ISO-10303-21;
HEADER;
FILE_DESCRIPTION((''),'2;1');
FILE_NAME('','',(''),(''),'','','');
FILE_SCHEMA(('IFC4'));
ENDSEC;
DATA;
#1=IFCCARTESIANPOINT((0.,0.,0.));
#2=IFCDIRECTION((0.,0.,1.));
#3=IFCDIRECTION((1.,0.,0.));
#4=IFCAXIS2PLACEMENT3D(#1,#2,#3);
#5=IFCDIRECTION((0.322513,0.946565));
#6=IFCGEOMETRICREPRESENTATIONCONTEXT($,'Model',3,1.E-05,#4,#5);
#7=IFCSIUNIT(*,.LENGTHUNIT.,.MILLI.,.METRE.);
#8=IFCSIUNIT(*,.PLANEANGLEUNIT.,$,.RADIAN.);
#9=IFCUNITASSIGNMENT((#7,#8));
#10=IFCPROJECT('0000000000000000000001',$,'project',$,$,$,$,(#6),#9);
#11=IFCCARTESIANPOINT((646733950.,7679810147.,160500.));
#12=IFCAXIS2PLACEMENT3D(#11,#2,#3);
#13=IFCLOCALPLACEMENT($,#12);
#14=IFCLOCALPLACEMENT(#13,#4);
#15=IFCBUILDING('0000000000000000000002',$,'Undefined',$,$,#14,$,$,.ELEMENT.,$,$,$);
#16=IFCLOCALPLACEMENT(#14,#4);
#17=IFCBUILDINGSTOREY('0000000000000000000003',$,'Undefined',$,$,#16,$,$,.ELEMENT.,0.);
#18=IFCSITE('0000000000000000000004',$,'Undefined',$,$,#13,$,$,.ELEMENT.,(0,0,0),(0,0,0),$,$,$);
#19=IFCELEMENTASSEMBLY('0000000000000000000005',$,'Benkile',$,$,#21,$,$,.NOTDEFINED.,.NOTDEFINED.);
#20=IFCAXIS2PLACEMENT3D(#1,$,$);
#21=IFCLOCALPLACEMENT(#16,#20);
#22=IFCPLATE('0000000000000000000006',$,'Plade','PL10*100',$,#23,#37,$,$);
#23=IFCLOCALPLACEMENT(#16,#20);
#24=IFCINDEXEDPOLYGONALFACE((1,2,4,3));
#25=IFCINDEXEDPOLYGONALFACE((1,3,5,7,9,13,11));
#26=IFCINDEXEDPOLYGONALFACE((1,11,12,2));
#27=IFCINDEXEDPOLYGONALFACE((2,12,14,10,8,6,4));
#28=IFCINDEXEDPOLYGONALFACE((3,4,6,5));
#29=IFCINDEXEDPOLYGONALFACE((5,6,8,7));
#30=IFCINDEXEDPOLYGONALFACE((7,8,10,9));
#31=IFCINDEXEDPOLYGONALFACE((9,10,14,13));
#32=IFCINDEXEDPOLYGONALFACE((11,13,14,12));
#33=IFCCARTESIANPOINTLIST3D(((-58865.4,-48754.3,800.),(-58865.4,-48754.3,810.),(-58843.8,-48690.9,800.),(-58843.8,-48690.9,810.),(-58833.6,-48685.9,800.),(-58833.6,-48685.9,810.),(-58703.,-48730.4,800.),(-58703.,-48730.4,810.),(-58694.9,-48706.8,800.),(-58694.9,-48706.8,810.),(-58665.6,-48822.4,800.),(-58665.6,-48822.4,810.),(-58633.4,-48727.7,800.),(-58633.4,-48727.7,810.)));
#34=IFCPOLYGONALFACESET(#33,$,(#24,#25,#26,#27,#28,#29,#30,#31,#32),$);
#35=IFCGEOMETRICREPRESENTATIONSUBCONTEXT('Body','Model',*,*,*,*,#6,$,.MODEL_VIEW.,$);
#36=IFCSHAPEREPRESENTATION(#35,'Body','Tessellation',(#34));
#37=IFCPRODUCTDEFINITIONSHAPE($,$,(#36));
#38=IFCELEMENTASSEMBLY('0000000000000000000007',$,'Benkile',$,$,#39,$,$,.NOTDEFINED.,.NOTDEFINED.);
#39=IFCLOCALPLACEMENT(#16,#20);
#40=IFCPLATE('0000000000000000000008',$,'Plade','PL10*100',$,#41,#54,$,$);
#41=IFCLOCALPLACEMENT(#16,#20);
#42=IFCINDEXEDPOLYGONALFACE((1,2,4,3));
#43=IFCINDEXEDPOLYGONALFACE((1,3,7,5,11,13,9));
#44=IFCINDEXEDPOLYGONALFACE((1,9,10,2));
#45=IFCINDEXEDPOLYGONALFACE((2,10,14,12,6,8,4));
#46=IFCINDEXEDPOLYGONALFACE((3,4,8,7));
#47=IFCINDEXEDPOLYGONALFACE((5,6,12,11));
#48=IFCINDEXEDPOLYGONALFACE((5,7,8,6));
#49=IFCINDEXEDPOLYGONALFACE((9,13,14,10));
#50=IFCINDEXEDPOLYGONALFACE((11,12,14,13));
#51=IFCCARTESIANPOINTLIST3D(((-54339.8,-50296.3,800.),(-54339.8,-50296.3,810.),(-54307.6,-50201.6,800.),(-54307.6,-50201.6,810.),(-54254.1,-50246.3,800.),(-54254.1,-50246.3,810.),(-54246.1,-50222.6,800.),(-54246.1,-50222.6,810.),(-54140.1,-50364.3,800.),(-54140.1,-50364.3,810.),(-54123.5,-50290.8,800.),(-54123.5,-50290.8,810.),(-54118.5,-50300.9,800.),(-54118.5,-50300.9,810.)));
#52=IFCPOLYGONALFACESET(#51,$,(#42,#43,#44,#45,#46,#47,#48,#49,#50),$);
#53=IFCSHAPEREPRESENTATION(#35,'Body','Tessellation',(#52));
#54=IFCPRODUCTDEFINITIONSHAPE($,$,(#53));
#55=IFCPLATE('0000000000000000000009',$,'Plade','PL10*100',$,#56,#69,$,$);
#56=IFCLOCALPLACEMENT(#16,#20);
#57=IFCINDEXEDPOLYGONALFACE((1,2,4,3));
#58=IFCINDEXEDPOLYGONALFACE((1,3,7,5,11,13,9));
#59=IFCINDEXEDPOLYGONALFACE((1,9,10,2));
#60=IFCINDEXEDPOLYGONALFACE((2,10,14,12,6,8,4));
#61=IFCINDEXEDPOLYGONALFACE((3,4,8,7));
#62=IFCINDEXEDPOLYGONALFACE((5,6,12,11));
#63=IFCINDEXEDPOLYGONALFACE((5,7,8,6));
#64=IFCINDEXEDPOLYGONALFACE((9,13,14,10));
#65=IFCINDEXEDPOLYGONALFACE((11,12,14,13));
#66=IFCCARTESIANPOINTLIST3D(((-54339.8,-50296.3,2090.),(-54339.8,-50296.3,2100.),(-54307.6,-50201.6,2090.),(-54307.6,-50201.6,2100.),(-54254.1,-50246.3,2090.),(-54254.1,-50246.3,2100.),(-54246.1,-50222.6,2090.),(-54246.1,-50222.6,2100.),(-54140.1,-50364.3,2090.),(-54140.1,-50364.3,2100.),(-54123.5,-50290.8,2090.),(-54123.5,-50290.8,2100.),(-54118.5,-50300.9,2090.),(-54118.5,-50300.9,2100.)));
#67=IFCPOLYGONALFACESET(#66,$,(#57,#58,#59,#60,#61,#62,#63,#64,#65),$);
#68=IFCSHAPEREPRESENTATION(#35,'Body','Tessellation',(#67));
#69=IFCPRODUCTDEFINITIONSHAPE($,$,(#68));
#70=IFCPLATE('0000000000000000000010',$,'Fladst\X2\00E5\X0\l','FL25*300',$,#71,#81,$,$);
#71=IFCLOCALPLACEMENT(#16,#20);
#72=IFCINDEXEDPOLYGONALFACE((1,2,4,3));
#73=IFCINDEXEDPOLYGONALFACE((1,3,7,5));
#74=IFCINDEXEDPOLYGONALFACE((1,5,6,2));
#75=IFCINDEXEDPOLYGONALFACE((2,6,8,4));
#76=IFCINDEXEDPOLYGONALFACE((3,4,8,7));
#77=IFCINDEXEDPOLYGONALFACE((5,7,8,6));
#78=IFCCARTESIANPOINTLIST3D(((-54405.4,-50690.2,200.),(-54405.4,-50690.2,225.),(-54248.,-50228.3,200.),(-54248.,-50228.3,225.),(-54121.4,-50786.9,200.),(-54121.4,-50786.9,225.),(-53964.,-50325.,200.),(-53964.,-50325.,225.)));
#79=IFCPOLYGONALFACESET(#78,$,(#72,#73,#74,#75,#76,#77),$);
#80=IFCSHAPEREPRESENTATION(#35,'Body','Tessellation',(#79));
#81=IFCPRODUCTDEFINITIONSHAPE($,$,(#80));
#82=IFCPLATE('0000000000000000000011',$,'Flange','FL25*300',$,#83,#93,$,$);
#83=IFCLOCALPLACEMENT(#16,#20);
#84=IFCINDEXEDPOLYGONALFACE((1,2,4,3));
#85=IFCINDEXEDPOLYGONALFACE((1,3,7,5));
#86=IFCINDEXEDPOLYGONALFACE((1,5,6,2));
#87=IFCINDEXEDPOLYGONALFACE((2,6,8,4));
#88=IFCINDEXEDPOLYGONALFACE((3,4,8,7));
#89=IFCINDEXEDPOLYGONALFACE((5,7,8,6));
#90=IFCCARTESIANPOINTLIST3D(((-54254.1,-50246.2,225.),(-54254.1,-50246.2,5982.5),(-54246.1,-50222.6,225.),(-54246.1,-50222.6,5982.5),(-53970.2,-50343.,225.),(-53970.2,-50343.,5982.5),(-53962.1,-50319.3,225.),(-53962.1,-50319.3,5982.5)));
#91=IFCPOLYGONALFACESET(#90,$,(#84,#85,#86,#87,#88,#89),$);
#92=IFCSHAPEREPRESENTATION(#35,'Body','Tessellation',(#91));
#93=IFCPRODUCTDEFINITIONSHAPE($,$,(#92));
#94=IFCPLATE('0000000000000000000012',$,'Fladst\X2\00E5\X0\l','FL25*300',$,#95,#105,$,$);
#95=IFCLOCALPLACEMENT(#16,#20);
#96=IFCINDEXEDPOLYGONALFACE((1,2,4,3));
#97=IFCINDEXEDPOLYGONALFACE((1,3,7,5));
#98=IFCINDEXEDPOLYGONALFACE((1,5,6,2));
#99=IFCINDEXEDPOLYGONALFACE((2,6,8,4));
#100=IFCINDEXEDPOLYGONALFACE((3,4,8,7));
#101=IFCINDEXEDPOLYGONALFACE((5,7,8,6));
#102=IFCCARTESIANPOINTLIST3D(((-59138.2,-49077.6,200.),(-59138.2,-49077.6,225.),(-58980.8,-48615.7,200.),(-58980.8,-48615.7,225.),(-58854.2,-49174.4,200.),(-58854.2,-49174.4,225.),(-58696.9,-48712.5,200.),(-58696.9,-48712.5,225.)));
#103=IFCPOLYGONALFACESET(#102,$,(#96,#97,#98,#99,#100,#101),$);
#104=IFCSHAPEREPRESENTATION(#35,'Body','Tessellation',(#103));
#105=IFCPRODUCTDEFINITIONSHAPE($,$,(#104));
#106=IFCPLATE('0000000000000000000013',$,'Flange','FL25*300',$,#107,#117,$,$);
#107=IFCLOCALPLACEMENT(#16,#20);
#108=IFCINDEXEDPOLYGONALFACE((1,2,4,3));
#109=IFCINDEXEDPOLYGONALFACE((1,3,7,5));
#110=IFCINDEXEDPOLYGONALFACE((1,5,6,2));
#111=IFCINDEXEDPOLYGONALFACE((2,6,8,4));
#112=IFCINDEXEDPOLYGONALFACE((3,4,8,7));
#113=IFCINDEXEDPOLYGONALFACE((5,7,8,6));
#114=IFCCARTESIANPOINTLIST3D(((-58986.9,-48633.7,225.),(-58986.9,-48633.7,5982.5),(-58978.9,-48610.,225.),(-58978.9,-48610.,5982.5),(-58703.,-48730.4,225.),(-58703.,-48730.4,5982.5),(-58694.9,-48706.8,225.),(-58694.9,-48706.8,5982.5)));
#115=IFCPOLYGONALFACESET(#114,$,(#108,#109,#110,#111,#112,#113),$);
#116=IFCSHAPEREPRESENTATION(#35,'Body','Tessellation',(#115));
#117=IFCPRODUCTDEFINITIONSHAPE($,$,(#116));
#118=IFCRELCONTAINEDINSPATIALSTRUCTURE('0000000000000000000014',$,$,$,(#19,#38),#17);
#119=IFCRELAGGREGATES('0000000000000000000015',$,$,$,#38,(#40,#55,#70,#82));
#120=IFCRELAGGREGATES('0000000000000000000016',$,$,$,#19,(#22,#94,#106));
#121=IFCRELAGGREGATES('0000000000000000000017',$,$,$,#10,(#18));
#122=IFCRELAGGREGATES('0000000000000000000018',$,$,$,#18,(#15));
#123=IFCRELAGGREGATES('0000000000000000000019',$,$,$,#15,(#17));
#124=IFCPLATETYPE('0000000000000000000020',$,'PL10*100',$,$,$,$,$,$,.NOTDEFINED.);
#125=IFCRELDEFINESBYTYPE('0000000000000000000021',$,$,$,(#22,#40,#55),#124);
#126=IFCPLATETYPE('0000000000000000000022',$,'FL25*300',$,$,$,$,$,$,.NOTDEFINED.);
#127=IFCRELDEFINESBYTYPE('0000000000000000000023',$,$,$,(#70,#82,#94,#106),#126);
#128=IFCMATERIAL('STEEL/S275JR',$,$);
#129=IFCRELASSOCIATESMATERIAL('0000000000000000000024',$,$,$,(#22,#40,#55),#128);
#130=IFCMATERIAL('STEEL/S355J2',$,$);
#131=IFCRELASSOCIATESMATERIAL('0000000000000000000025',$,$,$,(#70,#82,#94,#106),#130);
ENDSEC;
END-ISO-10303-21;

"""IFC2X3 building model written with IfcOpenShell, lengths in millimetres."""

from ifc_helpers import new_model, si_unit, direction, frame, origin_with_axes, place, context, subcontext, project, spatial, polyline, outline, extrude, boolean, clip, halfspace, material, type_object, element, aggregate, save


model = new_model("IFC2X3")

# Units and contexts
model_context = context("Model", 3, precision=1e-05, world=origin_with_axes(), true_north=direction((0.322513, 0.946565)))
body_context = subcontext(model_context, "Body", "Model", "MODEL_VIEW")
ifc_project = project(units=[si_unit("LENGTHUNIT", "METRE", prefix="MILLI"), si_unit("PLANEANGLEUNIT", "RADIAN")], contexts=[model_context])

# Site, building, storey
site_placement = place(None, frame((646733950.0, 7679810147.0, 160500.0), z_axis=(0.0, 0.0, 1.0), x_axis=(1.0, 0.0, 0.0)))
site = spatial("IfcSite", under=ifc_project, at=site_placement, Name="Undefined", CompositionType="ELEMENT", RefLatitude=(0, 0, 0), RefLongitude=(0, 0, 0))
building_placement = place(site_placement, origin_with_axes())
building = spatial("IfcBuilding", under=site, at=building_placement, Name="Undefined", CompositionType="ELEMENT")
storey_placement = place(building_placement, origin_with_axes())
storey = spatial("IfcBuildingStorey", under=building, at=storey_placement, Name="Undefined", CompositionType="ELEMENT", Elevation=0.0)

# Shared definitions
ifc_material_1 = material(Name="STEEL/S275JR")

# Element assembly
assembly_1_placement = place(storey_placement, origin_with_axes())
assembly_1 = element("IfcElementAssembly", 1, at=assembly_1_placement, inside=storey, Name="Benkile", AssemblyPlace="NOTDEFINED", PredefinedType="NOTDEFINED")
ifc_material_2 = material(Name="STEEL/S355J2")

# Plate
plate_type_1 = type_object("IfcPlateType", Name="PL10*100", PredefinedType="NOTDEFINED")
plate_1_placement = place(assembly_1_placement, frame((-58865.4, -48754.3, 805.0), z_axis=(0.0, 0.0, 1.0), x_axis=(0.946565, -0.322513, 0.0)))
plate_1 = element("IfcPlate", 2, at=plate_1_placement, type_object=plate_type_1, material=ifc_material_1, Name="Plade", Description="PL10*100", context=body_context, shape_type="CSG", body=[
    boolean("DIFFERENCE", extrude(outline(polyline([(0.0, 0.0), (211.0, 0.0), (211.0, 100.0), (146.0, 100.0), (146.0, 75.0), (0.0, 75.0), (0.0, 0.0)])), frame((0.0, 0.0, -5.0), z_axis=(0.0, 0.0, 1.0), x_axis=(1.0, 0.0, 0.0)), (0.0, 0.0, 1.0), 10.0), extrude(outline(polyline([(0.0, 0.0), (8.0, 0.0), (0.0, 8.0), (0.0, 0.0)])), frame((0.0, 75.0, 7.5), z_axis=(0.0, 0.0, -1.0), x_axis=(1.0, 0.0, 0.0)), (0.0, 0.0, 1.0), 15.0)),
])

# Element assembly, plates
assembly_2_placement = place(storey_placement, origin_with_axes())
assembly_2 = element("IfcElementAssembly", 3, at=assembly_2_placement, inside=storey, Name="Benkile", AssemblyPlace="NOTDEFINED", PredefinedType="NOTDEFINED")
plate_2_placement = place(assembly_2_placement, frame((-54107.9, -50269.7, 805.0), z_axis=(0.0, 0.0, 1.0), x_axis=(-0.946565, 0.322513, 0.0)))
plate_2 = element("IfcPlate", 4, at=plate_2_placement, type_object=plate_type_1, material=ifc_material_1, Name="Plade", Description="PL10*100", context=body_context, shape_type="CSG", body=[
    boolean("DIFFERENCE", extrude(outline(polyline([(0.0, 25.0), (146.0, 25.0), (146.0, 0.0), (211.0, 0.0), (211.0, 100.0), (0.0, 100.0), (0.0, 25.0)])), frame((0.0, 0.0, -5.0), z_axis=(0.0, 0.0, 1.0), x_axis=(1.0, 0.0, 0.0)), (0.0, 0.0, 1.0), 10.0), extrude(outline(polyline([(0.0, 0.0), (8.0, 0.0), (0.0, 8.0), (0.0, 0.0)])), frame((0.0, 25.0, -7.5), z_axis=(0.0, 0.0, 1.0), x_axis=(1.0, 0.0, 0.0)), (0.0, 0.0, 1.0), 15.0)),
])
plate_3_placement = place(assembly_2_placement, frame((-54107.9, -50269.7, 2095.0), z_axis=(0.0, 0.0, 1.0), x_axis=(-0.946565, 0.322513, 0.0)))
plate_3 = element("IfcPlate", 5, at=plate_3_placement, type_object=plate_type_1, material=ifc_material_1, Name="Plade", Description="PL10*100", context=body_context, shape_type="CSG", body=[
    boolean("DIFFERENCE", extrude(outline(polyline([(0.0, 25.0), (146.0, 25.0), (146.0, 0.0), (211.0, 0.0), (211.0, 100.0), (0.0, 100.0), (0.0, 25.0)])), frame((0.0, 0.0, -5.0), z_axis=(0.0, 0.0, 1.0), x_axis=(1.0, 0.0, 0.0)), (0.0, 0.0, 1.0), 10.0), extrude(outline(polyline([(0.0, 0.0), (8.0, 0.0), (0.0, 8.0), (0.0, 0.0)])), frame((0.0, 25.0, -7.5), z_axis=(0.0, 0.0, 1.0), x_axis=(1.0, 0.0, 0.0)), (0.0, 0.0, 1.0), 15.0)),
])
plate_type_2 = type_object("IfcPlateType", Name="FL25*300", PredefinedType="NOTDEFINED")
plate_4_placement = place(assembly_2_placement, frame((-54106.0, -50276.6, 212.5), z_axis=(0.0, 0.0, -1.0), x_axis=(-0.322513, -0.946565, 0.0)))
plate_4 = element("IfcPlate", 6, at=plate_4_placement, type_object=plate_type_2, material=ifc_material_2, Name="Fladstål", Description="FL25*300", context=body_context, shape_type="SweptSolid", body=[
    extrude(outline(polyline([(0.0, -150.0), (0.0, 150.0), (488.0, 150.0), (488.0, -150.0), (0.0, -150.0)])), frame((0.0, 0.0, -12.5), z_axis=(0.0, 0.0, 1.0), x_axis=(1.0, 0.0, 0.0)), (0.0, 0.0, 1.0), 25.0),
])
plate_5_placement = place(assembly_2_placement, frame((-54108.1, -50282.8, 200.0), z_axis=(-0.322513, -0.946565, 0.0), x_axis=(0.0, 0.0, 1.0)))
plate_5 = element("IfcPlate", 7, at=plate_5_placement, type_object=plate_type_2, material=ifc_material_2, Name="Flange", Description="FL25*300", context=body_context, shape_type="Clipping", body=[
    clip(extrude(outline(polyline([(25.0, -150.0), (25.0, 150.0), (5782.5, 150.0), (5782.5, -150.0), (25.0, -150.0)])), frame((0.0, 0.0, -12.5), z_axis=(0.0, 0.0, 1.0), x_axis=(1.0, 0.0, 0.0)), (0.0, 0.0, 1.0), 25.0), halfspace(frame((25.0, 0.0, 12.5), z_axis=(-1.0, 0.0, 0.0), x_axis=(0.0, 1.0, 0.0)), False)),
])

# Plates
plate_6_placement = place(assembly_1_placement, frame((-58838.8, -48664.1, 212.5), z_axis=(0.0, 0.0, -1.0), x_axis=(-0.322513, -0.946565, 0.0)))
plate_6 = element("IfcPlate", 8, at=plate_6_placement, type_object=plate_type_2, material=ifc_material_2, Name="Fladstål", Description="FL25*300", context=body_context, shape_type="SweptSolid", body=[
    extrude(outline(polyline([(0.0, -150.0), (0.0, 150.0), (488.0, 150.0), (488.0, -150.0), (0.0, -150.0)])), frame((0.0, 0.0, -12.5), z_axis=(0.0, 0.0, 1.0), x_axis=(1.0, 0.0, 0.0)), (0.0, 0.0, 1.0), 25.0),
])
plate_7_placement = place(assembly_1_placement, frame((-58840.9, -48670.2, 200.0), z_axis=(-0.322513, -0.946565, 0.0), x_axis=(0.0, 0.0, 1.0)))
plate_7 = element("IfcPlate", 9, at=plate_7_placement, type_object=plate_type_2, material=ifc_material_2, Name="Flange", Description="FL25*300", context=body_context, shape_type="Clipping", body=[
    clip(extrude(outline(polyline([(25.0, -150.0), (25.0, 150.0), (5782.5, 150.0), (5782.5, -150.0), (25.0, -150.0)])), frame((0.0, 0.0, -12.5), z_axis=(0.0, 0.0, 1.0), x_axis=(1.0, 0.0, 0.0)), (0.0, 0.0, 1.0), 25.0), halfspace(frame((25.0, 0.0, 12.5), z_axis=(-1.0, 0.0, 0.0), x_axis=(0.0, 1.0, 0.0)), False)),
])

aggregate(assembly_2, [plate_2, plate_3, plate_4, plate_5])
aggregate(assembly_1, [plate_1, plate_6, plate_7])

save(model, "model.ifc")
